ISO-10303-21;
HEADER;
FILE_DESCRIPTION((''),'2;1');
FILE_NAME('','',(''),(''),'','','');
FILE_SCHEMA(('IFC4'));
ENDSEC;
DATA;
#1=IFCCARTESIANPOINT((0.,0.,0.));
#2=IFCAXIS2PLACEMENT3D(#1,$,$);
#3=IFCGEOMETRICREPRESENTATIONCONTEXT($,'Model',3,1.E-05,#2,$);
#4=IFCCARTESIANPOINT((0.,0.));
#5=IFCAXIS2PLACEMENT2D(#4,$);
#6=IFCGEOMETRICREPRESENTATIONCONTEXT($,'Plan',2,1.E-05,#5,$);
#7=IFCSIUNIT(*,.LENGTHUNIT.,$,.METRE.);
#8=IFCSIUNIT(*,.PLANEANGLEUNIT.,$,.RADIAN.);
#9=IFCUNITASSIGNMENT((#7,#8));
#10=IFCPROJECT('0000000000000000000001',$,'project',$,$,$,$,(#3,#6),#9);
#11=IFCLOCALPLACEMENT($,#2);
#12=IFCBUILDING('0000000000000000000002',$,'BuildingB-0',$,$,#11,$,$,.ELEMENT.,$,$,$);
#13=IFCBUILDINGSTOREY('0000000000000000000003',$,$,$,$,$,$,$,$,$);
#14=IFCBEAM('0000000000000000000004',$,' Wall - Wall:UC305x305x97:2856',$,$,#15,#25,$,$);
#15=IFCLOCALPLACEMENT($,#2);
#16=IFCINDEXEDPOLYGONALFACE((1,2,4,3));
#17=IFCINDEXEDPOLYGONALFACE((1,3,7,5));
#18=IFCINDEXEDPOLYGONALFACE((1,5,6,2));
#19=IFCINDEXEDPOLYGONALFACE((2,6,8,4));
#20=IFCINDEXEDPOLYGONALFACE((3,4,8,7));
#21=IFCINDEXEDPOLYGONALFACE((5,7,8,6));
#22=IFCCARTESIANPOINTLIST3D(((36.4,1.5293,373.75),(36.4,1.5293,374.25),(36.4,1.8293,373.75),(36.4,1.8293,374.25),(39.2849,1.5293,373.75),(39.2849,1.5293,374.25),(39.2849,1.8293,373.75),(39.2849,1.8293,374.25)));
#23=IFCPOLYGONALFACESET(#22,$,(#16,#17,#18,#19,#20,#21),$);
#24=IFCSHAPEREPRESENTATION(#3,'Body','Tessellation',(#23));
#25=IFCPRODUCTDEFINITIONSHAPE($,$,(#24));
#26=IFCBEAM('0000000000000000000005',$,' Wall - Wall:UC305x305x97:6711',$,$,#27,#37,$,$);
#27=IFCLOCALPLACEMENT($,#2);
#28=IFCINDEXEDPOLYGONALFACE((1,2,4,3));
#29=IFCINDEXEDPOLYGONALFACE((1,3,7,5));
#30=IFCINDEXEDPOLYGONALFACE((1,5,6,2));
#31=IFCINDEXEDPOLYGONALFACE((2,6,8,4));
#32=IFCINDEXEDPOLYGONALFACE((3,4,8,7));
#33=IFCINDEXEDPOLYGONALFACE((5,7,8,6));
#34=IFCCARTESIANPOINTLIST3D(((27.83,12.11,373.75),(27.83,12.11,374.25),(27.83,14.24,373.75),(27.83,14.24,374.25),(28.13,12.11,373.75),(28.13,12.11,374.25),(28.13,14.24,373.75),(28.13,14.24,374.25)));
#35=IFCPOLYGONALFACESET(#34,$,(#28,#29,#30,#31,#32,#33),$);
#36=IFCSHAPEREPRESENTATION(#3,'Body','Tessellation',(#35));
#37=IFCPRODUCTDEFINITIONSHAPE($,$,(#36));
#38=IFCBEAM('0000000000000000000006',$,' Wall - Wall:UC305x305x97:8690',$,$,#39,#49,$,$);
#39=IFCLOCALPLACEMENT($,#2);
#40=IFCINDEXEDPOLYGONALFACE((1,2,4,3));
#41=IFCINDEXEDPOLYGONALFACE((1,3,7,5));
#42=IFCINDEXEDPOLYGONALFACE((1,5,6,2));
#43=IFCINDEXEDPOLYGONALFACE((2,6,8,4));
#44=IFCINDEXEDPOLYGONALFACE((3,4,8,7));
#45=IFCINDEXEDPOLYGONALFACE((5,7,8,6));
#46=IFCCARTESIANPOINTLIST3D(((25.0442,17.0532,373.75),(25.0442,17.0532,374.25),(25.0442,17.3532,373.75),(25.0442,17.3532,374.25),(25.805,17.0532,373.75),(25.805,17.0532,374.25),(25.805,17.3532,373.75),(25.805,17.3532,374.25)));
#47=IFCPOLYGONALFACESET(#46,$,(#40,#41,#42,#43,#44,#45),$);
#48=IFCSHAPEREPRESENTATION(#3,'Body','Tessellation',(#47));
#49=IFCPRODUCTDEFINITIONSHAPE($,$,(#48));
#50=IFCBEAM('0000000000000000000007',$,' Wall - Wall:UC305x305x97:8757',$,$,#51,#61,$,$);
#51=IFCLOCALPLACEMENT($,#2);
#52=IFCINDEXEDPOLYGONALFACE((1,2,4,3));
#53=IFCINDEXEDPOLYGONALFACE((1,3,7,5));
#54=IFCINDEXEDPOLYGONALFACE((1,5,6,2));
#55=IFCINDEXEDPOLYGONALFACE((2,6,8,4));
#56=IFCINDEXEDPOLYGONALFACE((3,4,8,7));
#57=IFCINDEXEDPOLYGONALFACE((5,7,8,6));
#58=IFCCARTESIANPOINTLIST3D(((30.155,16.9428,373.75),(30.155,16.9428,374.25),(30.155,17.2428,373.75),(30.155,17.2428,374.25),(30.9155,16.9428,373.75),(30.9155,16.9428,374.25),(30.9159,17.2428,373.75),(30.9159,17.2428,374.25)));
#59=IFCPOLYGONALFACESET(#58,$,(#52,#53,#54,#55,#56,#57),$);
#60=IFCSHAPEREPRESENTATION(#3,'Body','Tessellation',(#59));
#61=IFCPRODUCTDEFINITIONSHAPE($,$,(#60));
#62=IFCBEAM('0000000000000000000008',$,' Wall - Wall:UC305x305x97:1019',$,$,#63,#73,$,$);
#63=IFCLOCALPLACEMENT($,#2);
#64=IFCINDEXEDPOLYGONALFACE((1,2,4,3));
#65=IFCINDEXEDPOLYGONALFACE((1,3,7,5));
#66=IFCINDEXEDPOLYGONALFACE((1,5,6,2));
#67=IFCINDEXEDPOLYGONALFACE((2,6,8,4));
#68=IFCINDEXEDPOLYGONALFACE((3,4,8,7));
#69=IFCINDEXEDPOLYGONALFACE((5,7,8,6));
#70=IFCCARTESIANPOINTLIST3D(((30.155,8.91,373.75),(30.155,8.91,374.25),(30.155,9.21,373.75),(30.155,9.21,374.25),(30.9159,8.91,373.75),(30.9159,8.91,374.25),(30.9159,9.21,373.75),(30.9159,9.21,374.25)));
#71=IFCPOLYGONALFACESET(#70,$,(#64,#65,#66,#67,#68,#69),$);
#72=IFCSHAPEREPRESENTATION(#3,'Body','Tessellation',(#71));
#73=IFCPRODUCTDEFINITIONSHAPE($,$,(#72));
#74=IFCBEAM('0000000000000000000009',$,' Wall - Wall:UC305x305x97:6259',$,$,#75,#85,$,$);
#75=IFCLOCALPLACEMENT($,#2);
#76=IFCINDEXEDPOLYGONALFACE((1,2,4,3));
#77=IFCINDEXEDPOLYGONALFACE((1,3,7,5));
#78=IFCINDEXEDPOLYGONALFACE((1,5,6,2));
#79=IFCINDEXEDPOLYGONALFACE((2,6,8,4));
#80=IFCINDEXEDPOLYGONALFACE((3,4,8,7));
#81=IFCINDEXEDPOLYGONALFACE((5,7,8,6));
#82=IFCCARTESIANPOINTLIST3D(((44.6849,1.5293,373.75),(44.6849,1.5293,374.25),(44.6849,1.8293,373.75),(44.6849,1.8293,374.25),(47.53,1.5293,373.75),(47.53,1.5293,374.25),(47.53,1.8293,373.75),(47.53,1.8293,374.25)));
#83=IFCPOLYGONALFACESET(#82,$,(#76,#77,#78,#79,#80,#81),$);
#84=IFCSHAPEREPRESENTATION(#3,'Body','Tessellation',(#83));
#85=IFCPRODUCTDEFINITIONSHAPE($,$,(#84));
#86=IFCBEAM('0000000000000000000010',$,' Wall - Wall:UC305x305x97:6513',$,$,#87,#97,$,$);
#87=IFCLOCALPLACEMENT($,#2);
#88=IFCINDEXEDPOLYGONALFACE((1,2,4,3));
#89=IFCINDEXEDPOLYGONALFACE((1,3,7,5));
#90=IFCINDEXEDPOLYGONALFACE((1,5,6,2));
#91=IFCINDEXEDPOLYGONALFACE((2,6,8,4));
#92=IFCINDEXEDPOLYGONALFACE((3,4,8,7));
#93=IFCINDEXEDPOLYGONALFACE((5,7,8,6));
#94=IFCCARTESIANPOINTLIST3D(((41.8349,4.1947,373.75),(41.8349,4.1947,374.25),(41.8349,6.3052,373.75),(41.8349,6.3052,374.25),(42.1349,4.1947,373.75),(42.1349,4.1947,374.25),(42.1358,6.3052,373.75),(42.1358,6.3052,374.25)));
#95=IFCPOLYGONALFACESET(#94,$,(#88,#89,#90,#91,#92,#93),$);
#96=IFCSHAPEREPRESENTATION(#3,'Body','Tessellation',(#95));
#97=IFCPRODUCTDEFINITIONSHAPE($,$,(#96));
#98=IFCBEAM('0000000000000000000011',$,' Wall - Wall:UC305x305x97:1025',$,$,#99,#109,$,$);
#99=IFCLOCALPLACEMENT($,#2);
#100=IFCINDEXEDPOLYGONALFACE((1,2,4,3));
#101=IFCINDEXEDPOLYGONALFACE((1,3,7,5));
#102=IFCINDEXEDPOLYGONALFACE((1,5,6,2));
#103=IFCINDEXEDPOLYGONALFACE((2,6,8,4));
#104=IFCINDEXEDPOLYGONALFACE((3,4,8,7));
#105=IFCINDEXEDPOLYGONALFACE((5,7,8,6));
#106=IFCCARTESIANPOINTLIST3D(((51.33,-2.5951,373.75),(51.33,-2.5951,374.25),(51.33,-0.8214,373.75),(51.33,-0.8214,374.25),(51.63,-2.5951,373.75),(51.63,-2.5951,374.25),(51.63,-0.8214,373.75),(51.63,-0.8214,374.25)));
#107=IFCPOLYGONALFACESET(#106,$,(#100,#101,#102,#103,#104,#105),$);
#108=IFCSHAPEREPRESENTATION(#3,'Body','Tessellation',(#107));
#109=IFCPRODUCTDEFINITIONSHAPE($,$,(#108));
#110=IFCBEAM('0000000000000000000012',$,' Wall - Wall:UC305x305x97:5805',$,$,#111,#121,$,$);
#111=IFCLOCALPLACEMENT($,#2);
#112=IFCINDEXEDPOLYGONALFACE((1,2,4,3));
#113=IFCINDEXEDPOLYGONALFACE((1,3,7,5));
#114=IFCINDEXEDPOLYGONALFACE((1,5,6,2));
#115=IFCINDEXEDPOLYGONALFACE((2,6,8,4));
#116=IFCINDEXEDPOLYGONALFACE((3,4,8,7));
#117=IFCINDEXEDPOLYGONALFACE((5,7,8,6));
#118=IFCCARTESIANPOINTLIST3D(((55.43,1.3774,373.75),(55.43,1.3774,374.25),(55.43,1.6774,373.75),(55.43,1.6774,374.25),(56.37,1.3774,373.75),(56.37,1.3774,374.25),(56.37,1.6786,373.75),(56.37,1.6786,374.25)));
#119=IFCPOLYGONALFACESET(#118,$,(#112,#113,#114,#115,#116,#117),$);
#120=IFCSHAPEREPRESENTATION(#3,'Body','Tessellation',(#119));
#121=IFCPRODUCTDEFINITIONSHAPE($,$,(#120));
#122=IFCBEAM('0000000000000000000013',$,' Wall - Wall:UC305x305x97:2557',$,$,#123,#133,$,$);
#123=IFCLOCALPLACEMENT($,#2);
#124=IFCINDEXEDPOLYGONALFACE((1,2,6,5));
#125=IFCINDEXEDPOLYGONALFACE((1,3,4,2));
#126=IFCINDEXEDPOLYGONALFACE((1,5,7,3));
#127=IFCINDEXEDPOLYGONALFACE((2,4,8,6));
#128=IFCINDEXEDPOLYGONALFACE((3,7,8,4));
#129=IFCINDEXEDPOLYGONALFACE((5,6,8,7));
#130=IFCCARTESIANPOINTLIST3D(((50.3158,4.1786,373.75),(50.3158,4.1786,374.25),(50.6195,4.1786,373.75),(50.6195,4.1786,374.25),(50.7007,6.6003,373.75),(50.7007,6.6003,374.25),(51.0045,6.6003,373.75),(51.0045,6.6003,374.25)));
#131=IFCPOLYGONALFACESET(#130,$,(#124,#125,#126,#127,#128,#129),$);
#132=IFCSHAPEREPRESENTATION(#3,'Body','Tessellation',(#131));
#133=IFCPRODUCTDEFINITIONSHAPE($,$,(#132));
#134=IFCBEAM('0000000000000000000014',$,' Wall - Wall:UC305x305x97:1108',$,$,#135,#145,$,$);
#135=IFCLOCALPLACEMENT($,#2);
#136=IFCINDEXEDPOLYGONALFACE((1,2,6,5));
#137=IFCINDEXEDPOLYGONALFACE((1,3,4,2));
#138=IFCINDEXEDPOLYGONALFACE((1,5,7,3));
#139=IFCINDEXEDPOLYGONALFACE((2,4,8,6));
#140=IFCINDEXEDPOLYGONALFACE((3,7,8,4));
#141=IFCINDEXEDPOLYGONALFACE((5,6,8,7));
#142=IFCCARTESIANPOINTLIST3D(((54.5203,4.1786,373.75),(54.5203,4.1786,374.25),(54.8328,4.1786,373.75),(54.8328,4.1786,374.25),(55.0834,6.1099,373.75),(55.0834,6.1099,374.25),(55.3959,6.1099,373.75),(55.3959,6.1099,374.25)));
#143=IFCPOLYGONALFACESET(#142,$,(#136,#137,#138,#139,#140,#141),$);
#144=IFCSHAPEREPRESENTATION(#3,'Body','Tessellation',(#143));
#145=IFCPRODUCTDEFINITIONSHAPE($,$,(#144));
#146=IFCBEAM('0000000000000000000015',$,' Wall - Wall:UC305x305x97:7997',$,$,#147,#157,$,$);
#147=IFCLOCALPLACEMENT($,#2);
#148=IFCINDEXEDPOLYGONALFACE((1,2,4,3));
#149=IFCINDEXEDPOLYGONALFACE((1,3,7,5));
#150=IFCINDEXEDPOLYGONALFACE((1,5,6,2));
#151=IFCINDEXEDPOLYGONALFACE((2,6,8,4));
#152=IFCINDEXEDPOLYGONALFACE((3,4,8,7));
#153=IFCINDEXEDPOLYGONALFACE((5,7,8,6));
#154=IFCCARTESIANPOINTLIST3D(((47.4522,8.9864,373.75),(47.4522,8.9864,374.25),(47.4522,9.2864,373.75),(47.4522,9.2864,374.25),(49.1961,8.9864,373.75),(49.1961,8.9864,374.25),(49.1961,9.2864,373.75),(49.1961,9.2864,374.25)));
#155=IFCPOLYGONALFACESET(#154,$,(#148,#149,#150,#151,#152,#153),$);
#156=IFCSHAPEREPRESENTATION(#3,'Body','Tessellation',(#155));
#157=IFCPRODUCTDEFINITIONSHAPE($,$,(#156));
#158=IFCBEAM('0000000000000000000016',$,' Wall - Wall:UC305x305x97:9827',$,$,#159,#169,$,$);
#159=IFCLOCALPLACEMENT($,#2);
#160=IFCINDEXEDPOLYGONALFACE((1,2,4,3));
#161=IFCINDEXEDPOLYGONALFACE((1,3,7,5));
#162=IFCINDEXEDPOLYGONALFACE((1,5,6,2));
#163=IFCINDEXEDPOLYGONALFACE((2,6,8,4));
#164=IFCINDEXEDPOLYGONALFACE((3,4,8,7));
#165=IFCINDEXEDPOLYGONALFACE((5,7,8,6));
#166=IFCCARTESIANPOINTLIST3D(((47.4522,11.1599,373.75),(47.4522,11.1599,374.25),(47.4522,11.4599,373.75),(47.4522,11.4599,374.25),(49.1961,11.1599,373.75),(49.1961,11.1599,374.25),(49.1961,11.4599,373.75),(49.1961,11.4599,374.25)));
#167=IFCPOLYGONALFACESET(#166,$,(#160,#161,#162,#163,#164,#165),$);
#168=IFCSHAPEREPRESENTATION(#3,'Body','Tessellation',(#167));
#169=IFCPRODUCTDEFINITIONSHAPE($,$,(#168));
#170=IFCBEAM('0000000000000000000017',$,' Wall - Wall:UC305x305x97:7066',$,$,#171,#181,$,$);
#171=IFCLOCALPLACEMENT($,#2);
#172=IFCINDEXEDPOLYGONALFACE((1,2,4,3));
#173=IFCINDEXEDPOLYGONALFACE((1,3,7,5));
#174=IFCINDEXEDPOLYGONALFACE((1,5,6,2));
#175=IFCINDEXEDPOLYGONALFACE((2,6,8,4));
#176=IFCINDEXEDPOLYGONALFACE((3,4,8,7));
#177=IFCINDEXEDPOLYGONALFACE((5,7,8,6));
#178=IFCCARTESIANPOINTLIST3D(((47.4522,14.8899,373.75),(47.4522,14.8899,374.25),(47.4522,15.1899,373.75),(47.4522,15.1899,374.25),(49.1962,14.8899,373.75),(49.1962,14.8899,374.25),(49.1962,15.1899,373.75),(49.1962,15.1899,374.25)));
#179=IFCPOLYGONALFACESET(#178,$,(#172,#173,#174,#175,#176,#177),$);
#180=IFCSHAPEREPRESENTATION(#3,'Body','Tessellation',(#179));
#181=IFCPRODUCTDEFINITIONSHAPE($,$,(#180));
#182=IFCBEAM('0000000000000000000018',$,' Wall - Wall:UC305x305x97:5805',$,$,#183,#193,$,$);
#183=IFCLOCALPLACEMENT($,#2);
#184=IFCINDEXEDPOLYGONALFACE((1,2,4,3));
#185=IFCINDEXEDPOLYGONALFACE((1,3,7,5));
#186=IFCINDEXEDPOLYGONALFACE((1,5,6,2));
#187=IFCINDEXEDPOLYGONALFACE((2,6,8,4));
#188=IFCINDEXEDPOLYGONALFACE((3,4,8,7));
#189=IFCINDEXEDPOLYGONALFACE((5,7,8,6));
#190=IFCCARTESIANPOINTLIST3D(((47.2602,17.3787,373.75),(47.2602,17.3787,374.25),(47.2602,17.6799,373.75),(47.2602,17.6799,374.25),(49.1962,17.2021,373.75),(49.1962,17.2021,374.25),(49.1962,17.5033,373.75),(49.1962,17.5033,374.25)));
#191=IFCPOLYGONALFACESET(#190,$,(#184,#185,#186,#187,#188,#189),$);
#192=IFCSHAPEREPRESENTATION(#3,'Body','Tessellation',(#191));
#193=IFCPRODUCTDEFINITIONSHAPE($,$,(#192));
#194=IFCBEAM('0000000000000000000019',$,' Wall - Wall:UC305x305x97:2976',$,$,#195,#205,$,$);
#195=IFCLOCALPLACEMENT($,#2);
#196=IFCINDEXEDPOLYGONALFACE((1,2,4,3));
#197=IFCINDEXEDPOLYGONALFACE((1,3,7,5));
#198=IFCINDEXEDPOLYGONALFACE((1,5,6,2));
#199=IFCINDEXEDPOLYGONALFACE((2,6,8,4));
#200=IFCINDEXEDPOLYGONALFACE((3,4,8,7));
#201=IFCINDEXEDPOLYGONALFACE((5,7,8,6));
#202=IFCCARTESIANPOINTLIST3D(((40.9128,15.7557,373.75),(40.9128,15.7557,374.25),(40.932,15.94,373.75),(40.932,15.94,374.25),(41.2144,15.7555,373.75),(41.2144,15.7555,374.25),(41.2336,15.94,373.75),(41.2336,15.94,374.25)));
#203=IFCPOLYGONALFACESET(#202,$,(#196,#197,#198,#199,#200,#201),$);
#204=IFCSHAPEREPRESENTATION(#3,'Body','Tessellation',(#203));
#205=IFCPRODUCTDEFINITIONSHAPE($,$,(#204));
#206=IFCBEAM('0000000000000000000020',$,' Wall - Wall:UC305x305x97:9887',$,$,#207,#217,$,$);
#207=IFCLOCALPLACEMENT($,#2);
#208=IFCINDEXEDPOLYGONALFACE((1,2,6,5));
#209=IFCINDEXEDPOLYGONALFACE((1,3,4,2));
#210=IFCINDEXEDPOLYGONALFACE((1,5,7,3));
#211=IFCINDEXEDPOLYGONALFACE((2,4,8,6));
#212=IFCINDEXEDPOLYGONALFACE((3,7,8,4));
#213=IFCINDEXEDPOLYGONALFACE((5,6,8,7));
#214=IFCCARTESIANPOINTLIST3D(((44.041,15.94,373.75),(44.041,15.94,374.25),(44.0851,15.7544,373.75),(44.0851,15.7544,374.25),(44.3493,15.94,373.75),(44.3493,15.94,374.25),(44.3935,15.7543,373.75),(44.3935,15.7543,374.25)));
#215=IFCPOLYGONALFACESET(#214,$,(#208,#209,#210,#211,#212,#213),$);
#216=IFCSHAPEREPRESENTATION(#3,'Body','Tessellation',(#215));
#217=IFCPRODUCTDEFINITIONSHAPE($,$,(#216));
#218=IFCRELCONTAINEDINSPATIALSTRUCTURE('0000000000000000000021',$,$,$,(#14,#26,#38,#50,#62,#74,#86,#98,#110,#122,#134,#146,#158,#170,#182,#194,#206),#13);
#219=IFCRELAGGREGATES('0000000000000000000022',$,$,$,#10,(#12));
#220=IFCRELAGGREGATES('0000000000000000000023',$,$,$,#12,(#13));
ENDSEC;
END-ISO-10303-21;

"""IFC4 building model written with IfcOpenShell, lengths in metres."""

from ifc_helpers import new_model, si_unit, origin, origin_2d, place, context, project, spatial, polyline, outline, extrude, element, save


model = new_model("IFC4")

# Units and contexts
model_context = context("Model", 3, precision=1e-05, world=origin())
plan_context = context("Plan", 2, precision=1e-05, world=origin_2d())
ifc_project = project(units=[si_unit("LENGTHUNIT", "METRE"), si_unit("PLANEANGLEUNIT", "RADIAN")], contexts=[model_context, plan_context])

# Building, storey
building_placement = place(None, origin())
building = spatial("IfcBuilding", under=ifc_project, at=building_placement, Name="BuildingB-0", CompositionType="ELEMENT")
storey = spatial("IfcBuildingStorey", under=building)

# Beams
element("IfcBeam", 1, inside=storey, Name=" Wall - Wall:UC305x305x97:2856", context=model_context, shape_type="SweptSolid", body=[
    extrude(outline(polyline([(36.4, 1.5293, 373.75), (36.4, 1.8293, 373.75), (39.2849, 1.8293, 373.75), (39.2849, 1.5293, 373.75), (36.4, 1.5293, 373.75)])), None, (0.0, 0.0, 1.0), 0.5),
])
element("IfcBeam", 2, inside=storey, Name=" Wall - Wall:UC305x305x97:6711", context=model_context, shape_type="SweptSolid", body=[
    extrude(outline(polyline([(27.83, 12.11, 373.75), (28.13, 12.11, 373.75), (28.13, 14.24, 373.75), (27.83, 14.24, 373.75), (27.83, 12.11, 373.75)])), None, (0.0, 0.0, 1.0), 0.5),
])
element("IfcBeam", 3, inside=storey, Name=" Wall - Wall:UC305x305x97:8690", context=model_context, shape_type="SweptSolid", body=[
    extrude(outline(polyline([(25.0442, 17.0532, 373.75), (25.0442, 17.3532, 373.75), (25.805, 17.3532, 373.75), (25.805, 17.0532, 373.75), (25.0442, 17.0532, 373.75)])), None, (0.0, 0.0, 1.0), 0.5),
])
element("IfcBeam", 4, inside=storey, Name=" Wall - Wall:UC305x305x97:8757", context=model_context, shape_type="SweptSolid", body=[
    extrude(outline(polyline([(30.155, 16.9428, 373.75), (30.9155, 16.9428, 373.75), (30.9159, 17.2428, 373.75), (30.155, 17.2428, 373.75), (30.155, 16.9428, 373.75)])), None, (0.0, 0.0, 1.0), 0.5),
])
element("IfcBeam", 5, inside=storey, Name=" Wall - Wall:UC305x305x97:1019", context=model_context, shape_type="SweptSolid", body=[
    extrude(outline(polyline([(30.155, 8.91, 373.75), (30.9159, 8.91, 373.75), (30.9159, 9.21, 373.75), (30.155, 9.21, 373.75), (30.155, 8.91, 373.75)])), None, (0.0, 0.0, 1.0), 0.5),
])
element("IfcBeam", 6, inside=storey, Name=" Wall - Wall:UC305x305x97:6259", context=model_context, shape_type="SweptSolid", body=[
    extrude(outline(polyline([(44.6849, 1.5293, 373.75), (44.6849, 1.8293, 373.75), (47.53, 1.8293, 373.75), (47.53, 1.5293, 373.75), (44.6849, 1.5293, 373.75)])), None, (0.0, 0.0, 1.0), 0.5),
])
element("IfcBeam", 7, inside=storey, Name=" Wall - Wall:UC305x305x97:6513", context=model_context, shape_type="SweptSolid", body=[
    extrude(outline(polyline([(41.8349, 4.1947, 373.75), (42.1349, 4.1947, 373.75), (42.1358, 6.3052, 373.75), (41.8349, 6.3052, 373.75), (41.8349, 4.1947, 373.75)])), None, (0.0, 0.0, 1.0), 0.5),
])
element("IfcBeam", 8, inside=storey, Name=" Wall - Wall:UC305x305x97:1025", context=model_context, shape_type="SweptSolid", body=[
    extrude(outline(polyline([(51.33, -2.5951, 373.75), (51.63, -2.5951, 373.75), (51.63, -0.8214, 373.75), (51.33, -0.8214, 373.75), (51.33, -2.5951, 373.75)])), None, (0.0, 0.0, 1.0), 0.5),
])
element("IfcBeam", 9, inside=storey, Name=" Wall - Wall:UC305x305x97:5805", context=model_context, shape_type="SweptSolid", body=[
    extrude(outline(polyline([(55.43, 1.3774, 373.75), (55.43, 1.6774, 373.75), (56.37, 1.6786, 373.75), (56.37, 1.3774, 373.75), (55.43, 1.3774, 373.75)])), None, (0.0, 0.0, 1.0), 0.5),
])
element("IfcBeam", 10, inside=storey, Name=" Wall - Wall:UC305x305x97:2557", context=model_context, shape_type="SweptSolid", body=[
    extrude(outline(polyline([(50.3158, 4.1786, 373.75), (50.7007, 6.6003, 373.75), (51.0045, 6.6003, 373.75), (50.6195, 4.1786, 373.75), (50.3158, 4.1786, 373.75)])), None, (0.0, 0.0, 1.0), 0.5),
])
element("IfcBeam", 11, inside=storey, Name=" Wall - Wall:UC305x305x97:1108", context=model_context, shape_type="SweptSolid", body=[
    extrude(outline(polyline([(54.8328, 4.1786, 373.75), (54.5203, 4.1786, 373.75), (55.0834, 6.1099, 373.75), (55.3959, 6.1099, 373.75), (54.8328, 4.1786, 373.75)])), None, (0.0, 0.0, 1.0), 0.5),
])
element("IfcBeam", 12, inside=storey, Name=" Wall - Wall:UC305x305x97:7997", context=model_context, shape_type="SweptSolid", body=[
    extrude(outline(polyline([(47.4522, 8.9864, 373.75), (49.1961, 8.9864, 373.75), (49.1961, 9.2864, 373.75), (47.4522, 9.2864, 373.75), (47.4522, 8.9864, 373.75)])), None, (0.0, 0.0, 1.0), 0.5),
])
element("IfcBeam", 13, inside=storey, Name=" Wall - Wall:UC305x305x97:9827", context=model_context, shape_type="SweptSolid", body=[
    extrude(outline(polyline([(47.4522, 11.1599, 373.75), (47.4522, 11.4599, 373.75), (49.1961, 11.4599, 373.75), (49.1961, 11.1599, 373.75), (47.4522, 11.1599, 373.75)])), None, (0.0, 0.0, 1.0), 0.5),
])
element("IfcBeam", 14, inside=storey, Name=" Wall - Wall:UC305x305x97:7066", context=model_context, shape_type="SweptSolid", body=[
    extrude(outline(polyline([(47.4522, 14.8899, 373.75), (47.4522, 15.1899, 373.75), (49.1962, 15.1899, 373.75), (49.1962, 14.8899, 373.75), (47.4522, 14.8899, 373.75)])), None, (0.0, 0.0, 1.0), 0.5),
])
element("IfcBeam", 15, inside=storey, Name=" Wall - Wall:UC305x305x97:5805", context=model_context, shape_type="SweptSolid", body=[
    extrude(outline(polyline([(47.2602, 17.3787, 373.75), (47.2602, 17.6799, 373.75), (49.1962, 17.5033, 373.75), (49.1962, 17.2021, 373.75), (47.2602, 17.3787, 373.75)])), None, (0.0, 0.0, 1.0), 0.5),
])
element("IfcBeam", 16, inside=storey, Name=" Wall - Wall:UC305x305x97:2976", context=model_context, shape_type="SweptSolid", body=[
    extrude(outline(polyline([(40.9128, 15.7557, 373.75), (40.932, 15.94, 373.75), (41.2336, 15.94, 373.75), (41.2144, 15.7555, 373.75), (40.9128, 15.7557, 373.75)])), None, (0.0, 0.0, 1.0), 0.5),
])
element("IfcBeam", 17, inside=storey, Name=" Wall - Wall:UC305x305x97:9887", context=model_context, shape_type="SweptSolid", body=[
    extrude(outline(polyline([(44.0851, 15.7544, 373.75), (44.041, 15.94, 373.75), (44.3493, 15.94, 373.75), (44.3935, 15.7543, 373.75), (44.0851, 15.7544, 373.75)])), None, (0.0, 0.0, 1.0), 0.5),
])

save(model, "model.ifc")
